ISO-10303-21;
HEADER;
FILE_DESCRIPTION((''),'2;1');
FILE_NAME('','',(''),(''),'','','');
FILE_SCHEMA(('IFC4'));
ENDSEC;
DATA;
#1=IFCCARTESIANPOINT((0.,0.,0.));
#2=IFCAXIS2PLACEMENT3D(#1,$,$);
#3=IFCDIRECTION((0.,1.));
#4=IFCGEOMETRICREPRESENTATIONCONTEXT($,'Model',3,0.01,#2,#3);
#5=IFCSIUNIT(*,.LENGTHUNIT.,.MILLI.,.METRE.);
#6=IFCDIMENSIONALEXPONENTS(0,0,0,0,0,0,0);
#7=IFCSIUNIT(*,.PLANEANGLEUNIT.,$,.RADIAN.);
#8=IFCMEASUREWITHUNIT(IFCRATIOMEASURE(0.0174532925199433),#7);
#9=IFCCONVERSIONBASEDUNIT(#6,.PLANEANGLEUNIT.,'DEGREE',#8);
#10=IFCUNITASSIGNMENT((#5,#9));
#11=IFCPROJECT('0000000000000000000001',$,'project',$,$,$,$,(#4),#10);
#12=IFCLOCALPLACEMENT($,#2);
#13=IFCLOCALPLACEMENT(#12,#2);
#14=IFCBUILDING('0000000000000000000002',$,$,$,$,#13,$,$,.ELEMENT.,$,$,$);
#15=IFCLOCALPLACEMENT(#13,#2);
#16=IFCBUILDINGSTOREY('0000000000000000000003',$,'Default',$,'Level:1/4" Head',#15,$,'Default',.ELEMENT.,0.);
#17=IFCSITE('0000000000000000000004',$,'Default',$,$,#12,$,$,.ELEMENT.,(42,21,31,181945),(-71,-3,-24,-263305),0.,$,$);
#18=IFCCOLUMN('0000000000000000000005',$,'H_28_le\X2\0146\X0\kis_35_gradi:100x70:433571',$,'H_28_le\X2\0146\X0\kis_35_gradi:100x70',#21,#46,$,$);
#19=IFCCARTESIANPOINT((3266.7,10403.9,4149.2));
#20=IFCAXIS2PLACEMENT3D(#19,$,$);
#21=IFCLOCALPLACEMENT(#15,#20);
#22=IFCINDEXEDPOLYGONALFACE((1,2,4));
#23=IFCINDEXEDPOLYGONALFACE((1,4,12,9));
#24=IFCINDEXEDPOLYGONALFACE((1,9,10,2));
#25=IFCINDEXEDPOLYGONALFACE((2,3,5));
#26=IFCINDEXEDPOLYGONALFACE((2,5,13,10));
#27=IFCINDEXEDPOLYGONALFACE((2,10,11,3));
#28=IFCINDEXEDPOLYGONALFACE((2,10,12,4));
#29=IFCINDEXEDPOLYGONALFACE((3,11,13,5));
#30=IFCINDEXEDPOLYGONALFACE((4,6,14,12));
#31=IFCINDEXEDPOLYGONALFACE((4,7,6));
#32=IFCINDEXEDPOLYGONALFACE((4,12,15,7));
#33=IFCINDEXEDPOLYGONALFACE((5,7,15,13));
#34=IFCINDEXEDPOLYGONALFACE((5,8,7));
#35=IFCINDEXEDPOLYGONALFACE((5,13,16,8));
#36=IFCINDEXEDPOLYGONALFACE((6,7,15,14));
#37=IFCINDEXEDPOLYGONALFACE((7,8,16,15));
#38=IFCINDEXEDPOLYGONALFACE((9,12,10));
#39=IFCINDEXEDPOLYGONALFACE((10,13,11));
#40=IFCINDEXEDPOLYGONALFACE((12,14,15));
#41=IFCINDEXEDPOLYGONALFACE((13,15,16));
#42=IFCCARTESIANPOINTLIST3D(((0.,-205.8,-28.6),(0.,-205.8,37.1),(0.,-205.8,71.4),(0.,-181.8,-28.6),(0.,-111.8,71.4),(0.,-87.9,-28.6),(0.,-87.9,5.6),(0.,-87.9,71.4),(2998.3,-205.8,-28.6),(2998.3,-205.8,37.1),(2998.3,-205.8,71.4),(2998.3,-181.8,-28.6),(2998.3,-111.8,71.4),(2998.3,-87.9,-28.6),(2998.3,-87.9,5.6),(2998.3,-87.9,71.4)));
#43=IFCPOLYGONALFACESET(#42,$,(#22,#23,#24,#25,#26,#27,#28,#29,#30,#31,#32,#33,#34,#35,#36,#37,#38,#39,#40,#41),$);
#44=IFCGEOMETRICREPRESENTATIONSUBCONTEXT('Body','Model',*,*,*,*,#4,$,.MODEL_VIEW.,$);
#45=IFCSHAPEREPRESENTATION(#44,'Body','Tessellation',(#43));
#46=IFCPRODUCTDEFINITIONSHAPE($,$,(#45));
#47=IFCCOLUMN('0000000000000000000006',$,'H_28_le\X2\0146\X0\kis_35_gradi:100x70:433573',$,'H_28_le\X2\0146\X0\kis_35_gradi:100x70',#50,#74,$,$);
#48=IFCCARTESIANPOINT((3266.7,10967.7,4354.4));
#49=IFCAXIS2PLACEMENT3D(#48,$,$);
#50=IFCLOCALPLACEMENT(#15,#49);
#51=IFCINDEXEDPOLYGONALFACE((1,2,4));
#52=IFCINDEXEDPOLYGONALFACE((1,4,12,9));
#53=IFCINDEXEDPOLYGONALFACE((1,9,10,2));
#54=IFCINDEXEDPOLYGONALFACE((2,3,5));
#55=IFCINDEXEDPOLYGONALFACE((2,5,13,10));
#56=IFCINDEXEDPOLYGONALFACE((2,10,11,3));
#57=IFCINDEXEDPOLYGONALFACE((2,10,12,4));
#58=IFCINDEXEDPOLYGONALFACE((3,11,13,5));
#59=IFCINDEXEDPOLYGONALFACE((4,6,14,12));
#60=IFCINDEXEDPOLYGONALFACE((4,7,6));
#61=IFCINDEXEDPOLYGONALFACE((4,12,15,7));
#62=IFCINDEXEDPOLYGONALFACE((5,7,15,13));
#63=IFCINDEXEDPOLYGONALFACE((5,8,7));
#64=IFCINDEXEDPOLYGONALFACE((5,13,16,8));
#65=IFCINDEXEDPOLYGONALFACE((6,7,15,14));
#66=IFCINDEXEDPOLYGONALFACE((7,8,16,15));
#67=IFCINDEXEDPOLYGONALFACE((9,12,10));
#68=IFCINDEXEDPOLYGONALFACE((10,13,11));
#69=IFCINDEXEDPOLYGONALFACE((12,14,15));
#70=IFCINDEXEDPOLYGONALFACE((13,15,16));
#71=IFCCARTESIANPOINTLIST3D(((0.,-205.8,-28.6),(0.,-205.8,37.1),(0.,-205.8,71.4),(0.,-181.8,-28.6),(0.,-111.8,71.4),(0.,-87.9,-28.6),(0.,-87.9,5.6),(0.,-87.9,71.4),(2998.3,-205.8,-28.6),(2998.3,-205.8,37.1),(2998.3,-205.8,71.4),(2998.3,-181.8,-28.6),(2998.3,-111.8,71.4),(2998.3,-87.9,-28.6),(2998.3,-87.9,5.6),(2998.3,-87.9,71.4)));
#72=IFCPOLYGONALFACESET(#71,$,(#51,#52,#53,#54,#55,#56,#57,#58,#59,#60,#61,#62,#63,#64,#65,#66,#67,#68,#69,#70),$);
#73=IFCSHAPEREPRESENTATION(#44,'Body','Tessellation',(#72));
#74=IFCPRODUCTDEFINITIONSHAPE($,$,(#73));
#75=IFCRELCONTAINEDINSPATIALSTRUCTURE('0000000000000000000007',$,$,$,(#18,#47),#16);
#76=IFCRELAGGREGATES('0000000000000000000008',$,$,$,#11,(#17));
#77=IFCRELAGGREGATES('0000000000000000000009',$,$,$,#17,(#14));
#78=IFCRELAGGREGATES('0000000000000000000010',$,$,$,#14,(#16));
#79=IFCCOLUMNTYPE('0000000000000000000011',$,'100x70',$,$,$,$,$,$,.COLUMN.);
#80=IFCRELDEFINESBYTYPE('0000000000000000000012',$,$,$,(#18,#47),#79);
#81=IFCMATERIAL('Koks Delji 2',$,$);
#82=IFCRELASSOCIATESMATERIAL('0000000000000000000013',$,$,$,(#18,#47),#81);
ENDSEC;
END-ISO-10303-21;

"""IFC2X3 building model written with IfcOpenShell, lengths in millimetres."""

from ifc_helpers import new_model, entity, si_unit, converted_unit, direction, frame, frame_2d, origin, place, context, subcontext, project, spatial, rectangle, extrude, boolean, source, transform, mapped, material, type_object, type_shapes, element, save


model = new_model("IFC2X3")

# Units and contexts
model_context = context("Model", 3, precision=0.01, world=origin(), true_north=direction((0.0, 1.0)))
body_context = subcontext(model_context, "Body", "Model", "MODEL_VIEW")
ifc_project = project(units=[si_unit("LENGTHUNIT", "METRE", prefix="MILLI"), converted_unit("PLANEANGLEUNIT", "DEGREE", entity("IfcRatioMeasure", 0.0174532925199433), si_unit("PLANEANGLEUNIT", "RADIAN"), dimensions=[0, 0, 0, 0, 0, 0, 0])], contexts=[model_context])

# Site, building, storey
site_placement = place(None, origin())
site = spatial("IfcSite", under=ifc_project, at=site_placement, Name="Default", CompositionType="ELEMENT", RefLatitude=(42, 21, 31, 181945), RefLongitude=(-71, -3, -24, -263305), RefElevation=0.0)
building_placement = place(site_placement, origin())
building = spatial("IfcBuilding", under=site, at=building_placement, CompositionType="ELEMENT")
storey_placement = place(building_placement, origin())
storey = spatial("IfcBuildingStorey", under=building, at=storey_placement, Name="Default", ObjectType="Level:1/4\" Head", LongName="Default", CompositionType="ELEMENT", Elevation=0.0)

# Columns
ifc_material_1 = material(Name="Koks Delji 2")
column_type = type_object("IfcColumnType", Name="100x70", PredefinedType="COLUMN")
shared_shape_1 = source(origin(), body_context, "Body", "CSG", [
    boolean("DIFFERENCE", extrude(rectangle(XDim=2998.3, YDim=117.9, at=frame_2d((0.0, 0.0), x_axis=(1.0, 0.0))), frame((1499.1, -146.8, -28.6)), (0.0, 0.0, 1.0), 100.0), extrude(rectangle(XDim=70.0, YDim=100.0, at=frame_2d((0.0, 0.0), x_axis=(0.0, 1.0))), frame((0.0, -146.8, 21.4), z_axis=(-1.0, 0.0, 0.0), x_axis=(0.0, -0.939693, -0.34202)), (0.0, 0.0, -1.0), 2998.3)),
])
type_shapes(column_type, [shared_shape_1])
for number, where, name in (
    (1, (3266.7, 10403.9, 4149.2), "H_28_leņkis_35_gradi:100x70:433571"),
    (2, (3266.7, 10967.7, 4354.4), "H_28_leņkis_35_gradi:100x70:433573"),
):
    element("IfcColumn", number, at=place(storey_placement, frame(where)), inside=storey, type_object=column_type, material=ifc_material_1, Name=name, ObjectType="H_28_leņkis_35_gradi:100x70", context=body_context, shape_type="MappedRepresentation", body=[
        mapped(shared_shape_1, transform((0.0, 0.0, 0.0), scale=1.0)),
    ])

save(model, "model.ifc")
